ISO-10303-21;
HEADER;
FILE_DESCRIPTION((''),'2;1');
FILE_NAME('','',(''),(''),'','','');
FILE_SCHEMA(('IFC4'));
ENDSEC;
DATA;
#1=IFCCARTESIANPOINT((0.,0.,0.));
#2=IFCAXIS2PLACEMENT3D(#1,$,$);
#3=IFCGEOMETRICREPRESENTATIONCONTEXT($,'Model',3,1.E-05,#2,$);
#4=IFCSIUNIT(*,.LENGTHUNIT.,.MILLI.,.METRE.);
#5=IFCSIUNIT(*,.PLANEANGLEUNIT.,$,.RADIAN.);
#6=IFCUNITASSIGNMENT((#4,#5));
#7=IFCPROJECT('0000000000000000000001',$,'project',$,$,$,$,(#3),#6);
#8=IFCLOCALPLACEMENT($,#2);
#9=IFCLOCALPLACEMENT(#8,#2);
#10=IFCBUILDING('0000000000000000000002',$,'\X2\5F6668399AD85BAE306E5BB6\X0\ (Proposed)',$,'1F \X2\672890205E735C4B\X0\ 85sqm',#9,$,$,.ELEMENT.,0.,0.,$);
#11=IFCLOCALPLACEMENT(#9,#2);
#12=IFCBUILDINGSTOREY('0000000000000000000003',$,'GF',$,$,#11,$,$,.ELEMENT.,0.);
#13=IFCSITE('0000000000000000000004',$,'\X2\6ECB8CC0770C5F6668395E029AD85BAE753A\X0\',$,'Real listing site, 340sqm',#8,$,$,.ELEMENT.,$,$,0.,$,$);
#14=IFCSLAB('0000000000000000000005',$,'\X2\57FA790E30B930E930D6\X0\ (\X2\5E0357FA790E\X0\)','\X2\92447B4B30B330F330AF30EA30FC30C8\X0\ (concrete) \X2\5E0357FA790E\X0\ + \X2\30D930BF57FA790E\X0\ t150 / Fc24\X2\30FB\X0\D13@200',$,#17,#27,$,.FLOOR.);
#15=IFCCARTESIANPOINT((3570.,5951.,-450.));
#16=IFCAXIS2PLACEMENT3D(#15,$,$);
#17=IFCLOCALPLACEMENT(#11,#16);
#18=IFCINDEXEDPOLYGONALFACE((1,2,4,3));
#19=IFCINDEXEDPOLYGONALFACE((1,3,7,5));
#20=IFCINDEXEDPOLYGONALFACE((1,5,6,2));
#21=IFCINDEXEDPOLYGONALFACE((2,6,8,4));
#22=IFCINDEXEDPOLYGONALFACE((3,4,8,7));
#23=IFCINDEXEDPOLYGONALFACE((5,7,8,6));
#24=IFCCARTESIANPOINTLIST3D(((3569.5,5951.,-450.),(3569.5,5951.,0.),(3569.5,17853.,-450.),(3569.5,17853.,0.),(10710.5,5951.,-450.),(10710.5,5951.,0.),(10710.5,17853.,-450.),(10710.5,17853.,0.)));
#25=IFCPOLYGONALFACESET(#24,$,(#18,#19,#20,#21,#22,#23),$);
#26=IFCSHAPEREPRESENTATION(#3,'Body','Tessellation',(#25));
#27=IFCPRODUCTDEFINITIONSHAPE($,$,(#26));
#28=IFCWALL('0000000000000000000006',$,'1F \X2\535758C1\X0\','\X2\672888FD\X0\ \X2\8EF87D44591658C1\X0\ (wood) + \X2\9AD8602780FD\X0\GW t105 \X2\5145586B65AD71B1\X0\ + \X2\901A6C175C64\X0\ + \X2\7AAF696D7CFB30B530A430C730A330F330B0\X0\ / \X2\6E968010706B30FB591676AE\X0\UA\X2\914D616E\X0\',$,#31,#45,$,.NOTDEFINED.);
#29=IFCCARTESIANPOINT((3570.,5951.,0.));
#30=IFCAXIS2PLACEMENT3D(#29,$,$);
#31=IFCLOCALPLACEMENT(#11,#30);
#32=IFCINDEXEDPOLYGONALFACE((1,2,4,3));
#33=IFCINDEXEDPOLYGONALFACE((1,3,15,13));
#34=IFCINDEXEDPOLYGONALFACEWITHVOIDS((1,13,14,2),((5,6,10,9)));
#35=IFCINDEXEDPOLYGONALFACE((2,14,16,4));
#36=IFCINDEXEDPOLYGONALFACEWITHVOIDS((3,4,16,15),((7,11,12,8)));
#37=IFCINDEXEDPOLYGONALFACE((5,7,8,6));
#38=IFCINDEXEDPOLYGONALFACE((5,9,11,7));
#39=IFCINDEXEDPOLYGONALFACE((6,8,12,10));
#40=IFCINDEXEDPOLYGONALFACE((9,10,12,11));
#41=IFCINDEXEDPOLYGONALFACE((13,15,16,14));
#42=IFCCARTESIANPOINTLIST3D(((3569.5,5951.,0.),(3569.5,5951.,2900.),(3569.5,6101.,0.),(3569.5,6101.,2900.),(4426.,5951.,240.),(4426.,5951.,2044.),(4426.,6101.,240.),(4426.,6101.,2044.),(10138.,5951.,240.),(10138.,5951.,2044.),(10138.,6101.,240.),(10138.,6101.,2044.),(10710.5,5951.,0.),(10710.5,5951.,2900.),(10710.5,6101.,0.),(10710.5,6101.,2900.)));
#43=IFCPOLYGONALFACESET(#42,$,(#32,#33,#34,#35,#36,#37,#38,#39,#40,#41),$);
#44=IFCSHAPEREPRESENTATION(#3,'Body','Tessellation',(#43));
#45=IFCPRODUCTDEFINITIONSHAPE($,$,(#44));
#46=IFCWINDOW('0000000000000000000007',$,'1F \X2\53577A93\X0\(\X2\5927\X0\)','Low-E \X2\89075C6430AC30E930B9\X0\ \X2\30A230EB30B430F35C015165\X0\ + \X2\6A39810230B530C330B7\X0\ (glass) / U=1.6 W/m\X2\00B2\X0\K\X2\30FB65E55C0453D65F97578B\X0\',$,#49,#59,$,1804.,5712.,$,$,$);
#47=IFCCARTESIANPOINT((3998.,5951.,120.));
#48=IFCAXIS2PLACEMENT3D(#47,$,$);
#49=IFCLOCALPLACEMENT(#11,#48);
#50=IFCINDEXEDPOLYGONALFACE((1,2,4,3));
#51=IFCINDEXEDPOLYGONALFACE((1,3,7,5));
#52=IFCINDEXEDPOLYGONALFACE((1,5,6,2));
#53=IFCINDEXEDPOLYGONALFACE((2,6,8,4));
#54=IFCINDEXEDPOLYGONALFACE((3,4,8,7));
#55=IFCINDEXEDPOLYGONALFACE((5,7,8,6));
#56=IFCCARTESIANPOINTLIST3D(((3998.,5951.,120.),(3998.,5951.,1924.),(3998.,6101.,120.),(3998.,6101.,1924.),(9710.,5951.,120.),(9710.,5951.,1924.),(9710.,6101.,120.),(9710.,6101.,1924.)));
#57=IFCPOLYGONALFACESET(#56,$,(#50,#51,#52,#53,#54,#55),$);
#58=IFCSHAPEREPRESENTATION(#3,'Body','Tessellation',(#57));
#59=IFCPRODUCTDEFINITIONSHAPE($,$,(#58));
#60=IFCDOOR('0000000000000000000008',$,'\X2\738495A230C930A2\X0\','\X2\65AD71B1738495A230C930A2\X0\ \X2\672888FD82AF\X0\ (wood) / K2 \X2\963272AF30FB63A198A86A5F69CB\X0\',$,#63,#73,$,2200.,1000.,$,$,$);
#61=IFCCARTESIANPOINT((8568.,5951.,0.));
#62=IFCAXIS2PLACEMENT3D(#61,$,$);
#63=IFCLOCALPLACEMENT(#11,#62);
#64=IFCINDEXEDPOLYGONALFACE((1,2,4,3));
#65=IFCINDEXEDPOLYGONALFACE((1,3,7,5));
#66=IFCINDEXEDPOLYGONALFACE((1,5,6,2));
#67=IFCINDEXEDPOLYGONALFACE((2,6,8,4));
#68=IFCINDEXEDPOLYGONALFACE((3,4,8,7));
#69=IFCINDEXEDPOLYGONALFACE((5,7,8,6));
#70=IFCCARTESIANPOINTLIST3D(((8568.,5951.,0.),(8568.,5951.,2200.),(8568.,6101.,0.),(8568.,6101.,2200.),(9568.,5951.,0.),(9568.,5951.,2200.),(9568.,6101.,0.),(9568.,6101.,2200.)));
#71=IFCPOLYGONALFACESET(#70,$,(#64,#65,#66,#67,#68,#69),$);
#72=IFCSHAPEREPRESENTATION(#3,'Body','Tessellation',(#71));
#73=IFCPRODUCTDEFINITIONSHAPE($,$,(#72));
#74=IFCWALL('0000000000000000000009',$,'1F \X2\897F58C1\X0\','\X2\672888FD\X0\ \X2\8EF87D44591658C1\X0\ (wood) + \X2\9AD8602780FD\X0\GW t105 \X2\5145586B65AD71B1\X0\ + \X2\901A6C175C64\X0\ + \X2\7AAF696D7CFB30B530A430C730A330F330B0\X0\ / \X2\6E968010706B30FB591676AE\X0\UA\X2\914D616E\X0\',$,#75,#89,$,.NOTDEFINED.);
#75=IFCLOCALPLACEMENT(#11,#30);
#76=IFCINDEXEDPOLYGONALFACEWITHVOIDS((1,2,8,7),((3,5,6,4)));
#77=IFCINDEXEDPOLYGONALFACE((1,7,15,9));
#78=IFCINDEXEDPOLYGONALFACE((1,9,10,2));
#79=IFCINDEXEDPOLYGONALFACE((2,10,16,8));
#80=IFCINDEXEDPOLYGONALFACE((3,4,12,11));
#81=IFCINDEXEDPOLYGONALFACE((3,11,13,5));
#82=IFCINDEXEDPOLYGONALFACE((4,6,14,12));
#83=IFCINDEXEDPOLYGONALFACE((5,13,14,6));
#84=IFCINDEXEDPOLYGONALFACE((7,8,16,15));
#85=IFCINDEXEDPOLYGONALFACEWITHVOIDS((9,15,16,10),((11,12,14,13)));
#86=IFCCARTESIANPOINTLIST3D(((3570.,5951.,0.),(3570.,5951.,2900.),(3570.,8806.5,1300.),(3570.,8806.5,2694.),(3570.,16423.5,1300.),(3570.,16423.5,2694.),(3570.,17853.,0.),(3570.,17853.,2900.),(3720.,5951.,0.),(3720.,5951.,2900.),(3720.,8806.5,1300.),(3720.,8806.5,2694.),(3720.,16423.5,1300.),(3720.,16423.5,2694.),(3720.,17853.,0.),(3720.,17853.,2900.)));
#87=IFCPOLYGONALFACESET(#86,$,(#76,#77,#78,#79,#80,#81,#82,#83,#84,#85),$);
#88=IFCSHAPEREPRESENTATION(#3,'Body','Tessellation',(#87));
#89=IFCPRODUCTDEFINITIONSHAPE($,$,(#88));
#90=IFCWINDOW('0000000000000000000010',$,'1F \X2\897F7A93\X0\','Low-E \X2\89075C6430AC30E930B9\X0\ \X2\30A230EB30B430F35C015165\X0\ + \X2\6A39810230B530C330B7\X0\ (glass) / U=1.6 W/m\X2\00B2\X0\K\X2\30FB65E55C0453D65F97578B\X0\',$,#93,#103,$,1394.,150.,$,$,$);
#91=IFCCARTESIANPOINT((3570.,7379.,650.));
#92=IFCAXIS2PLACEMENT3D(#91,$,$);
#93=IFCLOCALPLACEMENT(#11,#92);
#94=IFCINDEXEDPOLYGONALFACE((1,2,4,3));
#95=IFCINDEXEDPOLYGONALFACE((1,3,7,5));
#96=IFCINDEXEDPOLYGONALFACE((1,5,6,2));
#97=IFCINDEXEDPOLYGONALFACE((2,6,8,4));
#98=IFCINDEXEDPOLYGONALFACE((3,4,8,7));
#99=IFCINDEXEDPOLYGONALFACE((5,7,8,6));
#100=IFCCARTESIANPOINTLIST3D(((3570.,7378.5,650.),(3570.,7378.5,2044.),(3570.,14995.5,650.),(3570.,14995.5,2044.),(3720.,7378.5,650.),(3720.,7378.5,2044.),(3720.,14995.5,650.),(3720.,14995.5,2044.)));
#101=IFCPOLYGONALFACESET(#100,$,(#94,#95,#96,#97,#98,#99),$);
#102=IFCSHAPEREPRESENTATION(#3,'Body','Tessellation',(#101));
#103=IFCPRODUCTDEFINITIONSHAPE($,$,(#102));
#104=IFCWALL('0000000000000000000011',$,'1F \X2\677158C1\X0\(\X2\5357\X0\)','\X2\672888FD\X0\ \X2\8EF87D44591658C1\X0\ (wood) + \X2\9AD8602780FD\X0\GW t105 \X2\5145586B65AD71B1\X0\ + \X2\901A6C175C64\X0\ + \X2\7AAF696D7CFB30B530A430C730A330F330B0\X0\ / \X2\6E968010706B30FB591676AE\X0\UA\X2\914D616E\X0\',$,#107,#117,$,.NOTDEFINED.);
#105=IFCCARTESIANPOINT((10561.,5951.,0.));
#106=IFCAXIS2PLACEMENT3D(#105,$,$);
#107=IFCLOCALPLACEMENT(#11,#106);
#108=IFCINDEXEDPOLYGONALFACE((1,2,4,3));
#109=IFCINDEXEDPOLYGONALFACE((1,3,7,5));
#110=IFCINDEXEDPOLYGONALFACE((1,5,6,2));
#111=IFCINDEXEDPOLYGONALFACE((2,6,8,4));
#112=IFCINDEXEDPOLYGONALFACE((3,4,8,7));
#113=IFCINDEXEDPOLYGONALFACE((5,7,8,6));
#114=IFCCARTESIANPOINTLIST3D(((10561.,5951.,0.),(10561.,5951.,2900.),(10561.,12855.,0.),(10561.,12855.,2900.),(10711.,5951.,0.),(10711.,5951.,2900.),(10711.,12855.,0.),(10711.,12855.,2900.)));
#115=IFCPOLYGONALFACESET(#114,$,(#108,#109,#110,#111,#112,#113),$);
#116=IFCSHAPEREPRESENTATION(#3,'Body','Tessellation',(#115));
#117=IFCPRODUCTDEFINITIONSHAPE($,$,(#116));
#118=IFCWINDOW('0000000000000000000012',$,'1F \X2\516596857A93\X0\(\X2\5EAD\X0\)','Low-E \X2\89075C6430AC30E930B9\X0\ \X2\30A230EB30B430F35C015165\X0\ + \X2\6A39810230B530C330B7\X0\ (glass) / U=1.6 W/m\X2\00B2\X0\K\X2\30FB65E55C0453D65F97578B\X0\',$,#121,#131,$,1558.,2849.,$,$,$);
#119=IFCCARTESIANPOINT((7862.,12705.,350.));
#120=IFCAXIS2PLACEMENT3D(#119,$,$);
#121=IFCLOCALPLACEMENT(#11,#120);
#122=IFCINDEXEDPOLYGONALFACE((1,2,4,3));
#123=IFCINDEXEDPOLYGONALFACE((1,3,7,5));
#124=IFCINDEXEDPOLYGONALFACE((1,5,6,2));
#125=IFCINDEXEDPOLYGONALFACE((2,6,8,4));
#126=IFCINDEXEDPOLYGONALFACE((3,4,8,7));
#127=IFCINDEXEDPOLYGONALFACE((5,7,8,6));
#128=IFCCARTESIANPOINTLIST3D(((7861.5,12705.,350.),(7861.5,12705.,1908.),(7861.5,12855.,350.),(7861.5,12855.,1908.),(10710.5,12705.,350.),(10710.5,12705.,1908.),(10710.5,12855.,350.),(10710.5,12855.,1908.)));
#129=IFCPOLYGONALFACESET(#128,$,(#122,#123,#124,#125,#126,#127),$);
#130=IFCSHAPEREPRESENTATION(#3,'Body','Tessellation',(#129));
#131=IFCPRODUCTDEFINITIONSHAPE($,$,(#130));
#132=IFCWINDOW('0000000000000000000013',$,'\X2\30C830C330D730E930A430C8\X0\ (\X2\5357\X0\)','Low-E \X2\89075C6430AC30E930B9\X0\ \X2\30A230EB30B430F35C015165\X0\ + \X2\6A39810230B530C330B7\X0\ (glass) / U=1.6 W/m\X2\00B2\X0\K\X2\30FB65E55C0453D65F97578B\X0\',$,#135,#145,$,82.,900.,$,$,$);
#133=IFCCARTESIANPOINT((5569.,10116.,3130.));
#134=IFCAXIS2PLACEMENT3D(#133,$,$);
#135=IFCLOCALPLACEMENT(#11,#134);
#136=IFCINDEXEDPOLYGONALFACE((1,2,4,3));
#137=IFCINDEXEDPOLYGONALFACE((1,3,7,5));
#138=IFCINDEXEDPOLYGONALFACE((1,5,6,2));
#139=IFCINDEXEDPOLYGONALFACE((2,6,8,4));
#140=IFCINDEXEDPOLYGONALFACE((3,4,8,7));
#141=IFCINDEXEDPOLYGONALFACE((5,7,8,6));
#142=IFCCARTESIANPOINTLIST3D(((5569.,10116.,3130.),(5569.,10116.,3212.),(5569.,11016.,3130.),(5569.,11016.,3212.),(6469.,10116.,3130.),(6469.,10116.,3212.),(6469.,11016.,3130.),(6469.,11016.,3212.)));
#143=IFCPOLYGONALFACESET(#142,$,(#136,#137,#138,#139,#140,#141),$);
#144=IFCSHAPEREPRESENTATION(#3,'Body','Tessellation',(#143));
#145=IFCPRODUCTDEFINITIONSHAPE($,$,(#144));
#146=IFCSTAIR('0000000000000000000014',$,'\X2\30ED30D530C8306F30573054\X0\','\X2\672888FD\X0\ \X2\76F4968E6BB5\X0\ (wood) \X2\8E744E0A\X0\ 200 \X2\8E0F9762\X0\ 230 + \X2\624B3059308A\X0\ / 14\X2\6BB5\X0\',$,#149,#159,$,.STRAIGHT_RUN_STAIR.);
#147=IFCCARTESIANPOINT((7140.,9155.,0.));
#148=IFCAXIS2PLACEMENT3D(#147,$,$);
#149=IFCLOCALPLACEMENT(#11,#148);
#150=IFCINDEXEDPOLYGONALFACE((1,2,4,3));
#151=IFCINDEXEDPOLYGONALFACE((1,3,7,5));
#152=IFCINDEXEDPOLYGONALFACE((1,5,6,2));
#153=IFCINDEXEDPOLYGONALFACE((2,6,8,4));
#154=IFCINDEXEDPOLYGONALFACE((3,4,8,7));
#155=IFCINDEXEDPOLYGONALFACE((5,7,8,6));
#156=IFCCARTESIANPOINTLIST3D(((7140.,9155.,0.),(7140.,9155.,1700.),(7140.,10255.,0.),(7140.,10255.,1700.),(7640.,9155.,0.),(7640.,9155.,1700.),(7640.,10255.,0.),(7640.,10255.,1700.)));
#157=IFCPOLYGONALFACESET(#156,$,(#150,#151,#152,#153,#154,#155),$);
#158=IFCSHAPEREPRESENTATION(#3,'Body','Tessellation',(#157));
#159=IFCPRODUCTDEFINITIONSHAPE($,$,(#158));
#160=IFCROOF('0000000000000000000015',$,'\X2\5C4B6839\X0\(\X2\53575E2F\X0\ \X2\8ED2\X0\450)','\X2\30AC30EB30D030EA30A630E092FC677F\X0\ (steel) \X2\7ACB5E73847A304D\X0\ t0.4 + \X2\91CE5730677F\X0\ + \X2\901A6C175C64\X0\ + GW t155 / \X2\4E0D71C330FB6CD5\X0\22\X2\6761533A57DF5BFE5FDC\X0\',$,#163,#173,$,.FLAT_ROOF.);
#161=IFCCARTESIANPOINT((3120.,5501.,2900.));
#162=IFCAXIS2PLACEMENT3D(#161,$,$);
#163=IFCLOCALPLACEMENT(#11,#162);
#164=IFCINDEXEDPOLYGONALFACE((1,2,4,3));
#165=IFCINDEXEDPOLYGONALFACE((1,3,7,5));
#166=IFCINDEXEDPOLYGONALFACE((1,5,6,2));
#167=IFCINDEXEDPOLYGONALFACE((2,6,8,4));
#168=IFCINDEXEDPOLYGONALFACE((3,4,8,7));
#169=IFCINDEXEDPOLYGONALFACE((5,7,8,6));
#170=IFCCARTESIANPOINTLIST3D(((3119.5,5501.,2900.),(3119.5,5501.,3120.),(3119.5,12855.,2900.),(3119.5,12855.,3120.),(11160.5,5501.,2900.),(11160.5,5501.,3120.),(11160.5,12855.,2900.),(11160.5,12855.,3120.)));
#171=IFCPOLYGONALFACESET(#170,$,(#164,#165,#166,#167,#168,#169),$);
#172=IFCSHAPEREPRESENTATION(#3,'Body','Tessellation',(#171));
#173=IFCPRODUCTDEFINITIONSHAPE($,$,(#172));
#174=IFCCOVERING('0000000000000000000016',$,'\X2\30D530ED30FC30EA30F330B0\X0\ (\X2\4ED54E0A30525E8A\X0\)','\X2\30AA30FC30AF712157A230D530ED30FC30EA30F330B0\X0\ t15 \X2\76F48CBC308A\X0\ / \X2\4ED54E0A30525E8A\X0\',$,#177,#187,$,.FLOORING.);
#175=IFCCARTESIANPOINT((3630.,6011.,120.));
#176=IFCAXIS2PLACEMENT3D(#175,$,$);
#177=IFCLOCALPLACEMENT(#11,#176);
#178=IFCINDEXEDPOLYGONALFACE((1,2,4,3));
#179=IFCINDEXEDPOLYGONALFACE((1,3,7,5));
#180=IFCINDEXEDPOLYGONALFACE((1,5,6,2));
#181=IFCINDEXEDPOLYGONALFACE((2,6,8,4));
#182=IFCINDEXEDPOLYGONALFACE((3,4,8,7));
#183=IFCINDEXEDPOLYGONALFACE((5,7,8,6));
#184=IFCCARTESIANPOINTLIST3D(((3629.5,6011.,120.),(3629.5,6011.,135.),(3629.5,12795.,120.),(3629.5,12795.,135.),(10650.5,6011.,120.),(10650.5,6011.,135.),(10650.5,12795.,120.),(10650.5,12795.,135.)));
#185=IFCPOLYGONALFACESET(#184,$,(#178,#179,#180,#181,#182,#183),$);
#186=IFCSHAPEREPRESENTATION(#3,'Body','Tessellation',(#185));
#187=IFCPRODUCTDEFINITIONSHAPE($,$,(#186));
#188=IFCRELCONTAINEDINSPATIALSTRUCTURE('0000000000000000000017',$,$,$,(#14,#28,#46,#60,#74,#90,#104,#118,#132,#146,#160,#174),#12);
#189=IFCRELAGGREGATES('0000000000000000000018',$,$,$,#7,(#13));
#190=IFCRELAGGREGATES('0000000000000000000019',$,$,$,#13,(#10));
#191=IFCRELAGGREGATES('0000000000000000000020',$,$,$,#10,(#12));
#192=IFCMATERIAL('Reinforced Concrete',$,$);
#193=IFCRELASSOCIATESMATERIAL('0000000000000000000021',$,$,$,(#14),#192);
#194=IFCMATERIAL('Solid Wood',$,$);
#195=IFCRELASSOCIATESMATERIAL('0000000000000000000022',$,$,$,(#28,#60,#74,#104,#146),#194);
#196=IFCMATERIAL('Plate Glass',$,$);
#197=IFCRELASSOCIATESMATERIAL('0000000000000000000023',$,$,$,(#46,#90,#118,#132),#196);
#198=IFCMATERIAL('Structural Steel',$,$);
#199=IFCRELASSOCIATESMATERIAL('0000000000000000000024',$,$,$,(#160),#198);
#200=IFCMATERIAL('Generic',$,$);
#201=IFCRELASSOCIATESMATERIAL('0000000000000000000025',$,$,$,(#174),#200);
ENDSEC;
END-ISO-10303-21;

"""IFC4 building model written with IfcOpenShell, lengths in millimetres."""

from ifc_helpers import new_model, si_unit, frame, frame_2d, origin, place, context, project, spatial, rectangle, extrude, material, element, fill, save


model = new_model("IFC4")

# Units and contexts
model_context = context("Model", 3, precision=1e-05, world=origin())
ifc_project = project(units=[si_unit("LENGTHUNIT", "METRE", prefix="MILLI"), si_unit("PLANEANGLEUNIT", "RADIAN")], contexts=[model_context])

# Site, building, storey
site_placement = place(None, origin())
site = spatial("IfcSite", under=ifc_project, at=site_placement, Name="滋賀県彦根市高宮町", ObjectType="Real listing site, 340sqm", CompositionType="ELEMENT", RefElevation=0.0)
building_placement = place(site_placement, origin())
building = spatial("IfcBuilding", under=site, at=building_placement, Name="彦根高宮の家 (Proposed)", ObjectType="1F 木造平屋 85sqm", CompositionType="ELEMENT", ElevationOfRefHeight=0.0, ElevationOfTerrain=0.0)
storey_placement = place(building_placement, origin())
storey = spatial("IfcBuildingStorey", under=building, at=storey_placement, Name="GF", CompositionType="ELEMENT", Elevation=0.0)

# Slab
ifc_material_1 = material(Name="Reinforced Concrete")
slab_1_placement = place(storey_placement, frame((3570.0, 5951.0, -450.0)))
element("IfcSlab", 1, at=slab_1_placement, inside=storey, material=ifc_material_1, Name="基礎スラブ (布基礎)", Description="鉄筋コンクリート (concrete) 布基礎 + ベタ基礎 t150 / Fc24・D13@200", PredefinedType="FLOOR", context=model_context, shape_type="SweptSolid", body=[
    extrude(rectangle(XDim=7141.0, YDim=11902.0, at=frame_2d((3570.0, 5951.0))), frame((3570.0, 5951.0, -450.0)), (0.0, 0.0, 1.0), 450.0),
])
ifc_material_2 = material(Name="Solid Wood")

# Wall, openings, window, door
wall_1_placement = place(storey_placement, frame((3570.0, 5951.0, 0.0)))
wall_1 = element("IfcWall", 2, at=wall_1_placement, inside=storey, material=ifc_material_2, Name="1F 南壁", Description="木製 軸組外壁 (wood) + 高性能GW t105 充填断熱 + 通気層 + 窯業系サイディング / 準耐火・外皮UA配慮", PredefinedType="NOTDEFINED", context=model_context, shape_type="SweptSolid", body=[
    extrude(rectangle(XDim=7141.0, YDim=150.0, at=frame_2d((3570.0, 75.0))), frame((3570.0, 5951.0, 0.0)), (0.0, 0.0, 1.0), 2900.0),
])
opening_1_placement = place(storey_placement, frame((3998.0, 5951.0, 120.0)))
opening_1 = element("IfcOpeningElement", 3, at=opening_1_placement, cuts=wall_1, PredefinedType="NOTDEFINED", context=model_context, shape_type="SweptSolid", body=[
    extrude(rectangle(XDim=5712.0, YDim=150.0, at=frame_2d((2856.0, 75.0))), frame((3998.0, 5951.0, 120.0)), (0.0, 0.0, 1.0), 1804.0),
])
opening_2_placement = place(storey_placement, frame((8568.0, 5951.0, 0.0)))
opening_2 = element("IfcOpeningElement", 4, at=opening_2_placement, cuts=wall_1, PredefinedType="NOTDEFINED", context=model_context, shape_type="SweptSolid", body=[
    extrude(rectangle(XDim=1000.0, YDim=150.0, at=frame_2d((500.0, 75.0))), frame((8568.0, 5951.0, 0.0)), (0.0, 0.0, 1.0), 2200.0),
])
ifc_material_3 = material(Name="Plate Glass")
window_1_placement = place(storey_placement, frame((3998.0, 5951.0, 120.0)))
window_1 = element("IfcWindow", 5, at=window_1_placement, inside=storey, material=ifc_material_3, Name="1F 南窓(大)", Description="Low-E 複層ガラス アルゴン封入 + 樹脂サッシ (glass) / U=1.6 W/m²K・日射取得型", OverallHeight=1804.0, OverallWidth=5712.0, context=model_context, shape_type="SweptSolid", body=[
    extrude(rectangle(XDim=5712.0, YDim=150.0, at=frame_2d((2856.0, 75.0))), frame((3998.0, 5951.0, 120.0)), (0.0, 0.0, 1.0), 1804.0),
])
fill(opening_1, window_1)
door_1_placement = place(storey_placement, frame((8568.0, 5951.0, 0.0)))
door_1 = element("IfcDoor", 6, at=door_1_placement, inside=storey, material=ifc_material_2, Name="玄関ドア", Description="断熱玄関ドア 木製芯 (wood) / K2 防犯・採風機構", OverallHeight=2200.0, OverallWidth=1000.0, context=model_context, shape_type="SweptSolid", body=[
    extrude(rectangle(XDim=1000.0, YDim=150.0, at=frame_2d((500.0, 75.0))), frame((8568.0, 5951.0, 0.0)), (0.0, 0.0, 1.0), 2200.0),
])
fill(opening_2, door_1)

# Walls, openings, windows
wall_2_placement = place(storey_placement, frame((3570.0, 5951.0, 0.0)))
wall_2 = element("IfcWall", 7, at=wall_2_placement, inside=storey, material=ifc_material_2, Name="1F 西壁", Description="木製 軸組外壁 (wood) + 高性能GW t105 充填断熱 + 通気層 + 窯業系サイディング / 準耐火・外皮UA配慮", PredefinedType="NOTDEFINED", context=model_context, shape_type="SweptSolid", body=[
    extrude(rectangle(XDim=150.0, YDim=11902.0, at=frame_2d((75.0, 5951.0))), frame((3570.0, 5951.0, 0.0)), (0.0, 0.0, 1.0), 2900.0),
])
opening_3_placement = place(storey_placement, frame((3570.0, 7379.0, 650.0)))
opening_3 = element("IfcOpeningElement", 8, at=opening_3_placement, cuts=wall_2, PredefinedType="NOTDEFINED", context=model_context, shape_type="SweptSolid", body=[
    extrude(rectangle(XDim=150.0, YDim=7617.0, at=frame_2d((75.0, 3808.0))), frame((3570.0, 7379.0, 650.0)), (0.0, 0.0, 1.0), 1394.0),
])
window_2_placement = place(storey_placement, frame((3570.0, 7379.0, 650.0)))
window_2 = element("IfcWindow", 9, at=window_2_placement, inside=storey, material=ifc_material_3, Name="1F 西窓", Description="Low-E 複層ガラス アルゴン封入 + 樹脂サッシ (glass) / U=1.6 W/m²K・日射取得型", OverallHeight=1394.0, OverallWidth=150.0, context=model_context, shape_type="SweptSolid", body=[
    extrude(rectangle(XDim=150.0, YDim=7617.0, at=frame_2d((75.0, 3808.0))), frame((3570.0, 7379.0, 650.0)), (0.0, 0.0, 1.0), 1394.0),
])
fill(opening_3, window_2)
wall_3_placement = place(storey_placement, frame((10561.0, 5951.0, 0.0)))
wall_3 = element("IfcWall", 10, at=wall_3_placement, inside=storey, material=ifc_material_2, Name="1F 東壁(南)", Description="木製 軸組外壁 (wood) + 高性能GW t105 充填断熱 + 通気層 + 窯業系サイディング / 準耐火・外皮UA配慮", PredefinedType="NOTDEFINED", context=model_context, shape_type="SweptSolid", body=[
    extrude(rectangle(XDim=150.0, YDim=6904.0, at=frame_2d((75.0, 3452.0))), frame((10561.0, 5951.0, 0.0)), (0.0, 0.0, 1.0), 2900.0),
])
opening_4_placement = place(storey_placement, frame((7862.0, 12705.0, 350.0)))
opening_4 = element("IfcOpeningElement", 11, at=opening_4_placement, cuts=wall_3, PredefinedType="NOTDEFINED", context=model_context, shape_type="SweptSolid", body=[
    extrude(rectangle(XDim=2849.0, YDim=150.0, at=frame_2d((1424.0, 75.0))), frame((7862.0, 12705.0, 350.0)), (0.0, 0.0, 1.0), 1558.0),
])
window_3_placement = place(storey_placement, frame((7862.0, 12705.0, 350.0)))
window_3 = element("IfcWindow", 12, at=window_3_placement, inside=storey, material=ifc_material_3, Name="1F 入隅窓(庭)", Description="Low-E 複層ガラス アルゴン封入 + 樹脂サッシ (glass) / U=1.6 W/m²K・日射取得型", OverallHeight=1558.0, OverallWidth=2849.0, context=model_context, shape_type="SweptSolid", body=[
    extrude(rectangle(XDim=2849.0, YDim=150.0, at=frame_2d((1424.0, 75.0))), frame((7862.0, 12705.0, 350.0)), (0.0, 0.0, 1.0), 1558.0),
])
fill(opening_4, window_3)

# Window
window_4_placement = place(storey_placement, frame((5569.0, 10116.0, 3130.0)))
element("IfcWindow", 13, at=window_4_placement, inside=storey, material=ifc_material_3, Name="トップライト (南)", Description="Low-E 複層ガラス アルゴン封入 + 樹脂サッシ (glass) / U=1.6 W/m²K・日射取得型", OverallHeight=82.0, OverallWidth=900.0, context=model_context, shape_type="SweptSolid", body=[
    extrude(rectangle(XDim=900.0, YDim=900.0, at=frame_2d((450.0, 450.0))), frame((5569.0, 10116.0, 3130.0)), (0.0, 0.0, 1.0), 82.0),
])

# Stair
stair_placement = place(storey_placement, frame((7140.0, 9155.0, 0.0)))
element("IfcStair", 14, at=stair_placement, inside=storey, material=ifc_material_2, Name="ロフトはしご", Description="木製 直階段 (wood) 蹴上 200 踏面 230 + 手すり / 14段", PredefinedType="STRAIGHT_RUN_STAIR", context=model_context, shape_type="SweptSolid", body=[
    extrude(rectangle(XDim=500.0, YDim=1100.0, at=frame_2d((250.0, 550.0))), frame((7140.0, 9155.0, 0.0)), (0.0, 0.0, 1.0), 1700.0),
])

# Roof
ifc_material_4 = material(Name="Structural Steel")
roof_placement = place(storey_placement, frame((3120.0, 5501.0, 2900.0)))
element("IfcRoof", 15, at=roof_placement, inside=storey, material=ifc_material_4, Name="屋根(南帯 軒450)", Description="ガルバリウム鋼板 (steel) 立平葺き t0.4 + 野地板 + 通気層 + GW t155 / 不燃・法22条区域対応", PredefinedType="FLAT_ROOF", context=model_context, shape_type="SweptSolid", body=[
    extrude(rectangle(XDim=8041.0, YDim=7354.0, at=frame_2d((4020.0, 3677.0))), frame((3120.0, 5501.0, 2900.0)), (0.0, 0.0, 1.0), 220.0),
])

# Covering
ifc_material_5 = material(Name="Generic")
covering_placement = place(storey_placement, frame((3630.0, 6011.0, 120.0)))
element("IfcCovering", 16, at=covering_placement, inside=storey, material=ifc_material_5, Name="フローリング (仕上げ床)", Description="オーク無垢フローリング t15 直貼り / 仕上げ床", PredefinedType="FLOORING", context=model_context, shape_type="SweptSolid", body=[
    extrude(rectangle(XDim=7021.0, YDim=6784.0, at=frame_2d((3510.0, 3392.0))), frame((3630.0, 6011.0, 120.0)), (0.0, 0.0, 1.0), 15.0),
])

save(model, "model.ifc")
